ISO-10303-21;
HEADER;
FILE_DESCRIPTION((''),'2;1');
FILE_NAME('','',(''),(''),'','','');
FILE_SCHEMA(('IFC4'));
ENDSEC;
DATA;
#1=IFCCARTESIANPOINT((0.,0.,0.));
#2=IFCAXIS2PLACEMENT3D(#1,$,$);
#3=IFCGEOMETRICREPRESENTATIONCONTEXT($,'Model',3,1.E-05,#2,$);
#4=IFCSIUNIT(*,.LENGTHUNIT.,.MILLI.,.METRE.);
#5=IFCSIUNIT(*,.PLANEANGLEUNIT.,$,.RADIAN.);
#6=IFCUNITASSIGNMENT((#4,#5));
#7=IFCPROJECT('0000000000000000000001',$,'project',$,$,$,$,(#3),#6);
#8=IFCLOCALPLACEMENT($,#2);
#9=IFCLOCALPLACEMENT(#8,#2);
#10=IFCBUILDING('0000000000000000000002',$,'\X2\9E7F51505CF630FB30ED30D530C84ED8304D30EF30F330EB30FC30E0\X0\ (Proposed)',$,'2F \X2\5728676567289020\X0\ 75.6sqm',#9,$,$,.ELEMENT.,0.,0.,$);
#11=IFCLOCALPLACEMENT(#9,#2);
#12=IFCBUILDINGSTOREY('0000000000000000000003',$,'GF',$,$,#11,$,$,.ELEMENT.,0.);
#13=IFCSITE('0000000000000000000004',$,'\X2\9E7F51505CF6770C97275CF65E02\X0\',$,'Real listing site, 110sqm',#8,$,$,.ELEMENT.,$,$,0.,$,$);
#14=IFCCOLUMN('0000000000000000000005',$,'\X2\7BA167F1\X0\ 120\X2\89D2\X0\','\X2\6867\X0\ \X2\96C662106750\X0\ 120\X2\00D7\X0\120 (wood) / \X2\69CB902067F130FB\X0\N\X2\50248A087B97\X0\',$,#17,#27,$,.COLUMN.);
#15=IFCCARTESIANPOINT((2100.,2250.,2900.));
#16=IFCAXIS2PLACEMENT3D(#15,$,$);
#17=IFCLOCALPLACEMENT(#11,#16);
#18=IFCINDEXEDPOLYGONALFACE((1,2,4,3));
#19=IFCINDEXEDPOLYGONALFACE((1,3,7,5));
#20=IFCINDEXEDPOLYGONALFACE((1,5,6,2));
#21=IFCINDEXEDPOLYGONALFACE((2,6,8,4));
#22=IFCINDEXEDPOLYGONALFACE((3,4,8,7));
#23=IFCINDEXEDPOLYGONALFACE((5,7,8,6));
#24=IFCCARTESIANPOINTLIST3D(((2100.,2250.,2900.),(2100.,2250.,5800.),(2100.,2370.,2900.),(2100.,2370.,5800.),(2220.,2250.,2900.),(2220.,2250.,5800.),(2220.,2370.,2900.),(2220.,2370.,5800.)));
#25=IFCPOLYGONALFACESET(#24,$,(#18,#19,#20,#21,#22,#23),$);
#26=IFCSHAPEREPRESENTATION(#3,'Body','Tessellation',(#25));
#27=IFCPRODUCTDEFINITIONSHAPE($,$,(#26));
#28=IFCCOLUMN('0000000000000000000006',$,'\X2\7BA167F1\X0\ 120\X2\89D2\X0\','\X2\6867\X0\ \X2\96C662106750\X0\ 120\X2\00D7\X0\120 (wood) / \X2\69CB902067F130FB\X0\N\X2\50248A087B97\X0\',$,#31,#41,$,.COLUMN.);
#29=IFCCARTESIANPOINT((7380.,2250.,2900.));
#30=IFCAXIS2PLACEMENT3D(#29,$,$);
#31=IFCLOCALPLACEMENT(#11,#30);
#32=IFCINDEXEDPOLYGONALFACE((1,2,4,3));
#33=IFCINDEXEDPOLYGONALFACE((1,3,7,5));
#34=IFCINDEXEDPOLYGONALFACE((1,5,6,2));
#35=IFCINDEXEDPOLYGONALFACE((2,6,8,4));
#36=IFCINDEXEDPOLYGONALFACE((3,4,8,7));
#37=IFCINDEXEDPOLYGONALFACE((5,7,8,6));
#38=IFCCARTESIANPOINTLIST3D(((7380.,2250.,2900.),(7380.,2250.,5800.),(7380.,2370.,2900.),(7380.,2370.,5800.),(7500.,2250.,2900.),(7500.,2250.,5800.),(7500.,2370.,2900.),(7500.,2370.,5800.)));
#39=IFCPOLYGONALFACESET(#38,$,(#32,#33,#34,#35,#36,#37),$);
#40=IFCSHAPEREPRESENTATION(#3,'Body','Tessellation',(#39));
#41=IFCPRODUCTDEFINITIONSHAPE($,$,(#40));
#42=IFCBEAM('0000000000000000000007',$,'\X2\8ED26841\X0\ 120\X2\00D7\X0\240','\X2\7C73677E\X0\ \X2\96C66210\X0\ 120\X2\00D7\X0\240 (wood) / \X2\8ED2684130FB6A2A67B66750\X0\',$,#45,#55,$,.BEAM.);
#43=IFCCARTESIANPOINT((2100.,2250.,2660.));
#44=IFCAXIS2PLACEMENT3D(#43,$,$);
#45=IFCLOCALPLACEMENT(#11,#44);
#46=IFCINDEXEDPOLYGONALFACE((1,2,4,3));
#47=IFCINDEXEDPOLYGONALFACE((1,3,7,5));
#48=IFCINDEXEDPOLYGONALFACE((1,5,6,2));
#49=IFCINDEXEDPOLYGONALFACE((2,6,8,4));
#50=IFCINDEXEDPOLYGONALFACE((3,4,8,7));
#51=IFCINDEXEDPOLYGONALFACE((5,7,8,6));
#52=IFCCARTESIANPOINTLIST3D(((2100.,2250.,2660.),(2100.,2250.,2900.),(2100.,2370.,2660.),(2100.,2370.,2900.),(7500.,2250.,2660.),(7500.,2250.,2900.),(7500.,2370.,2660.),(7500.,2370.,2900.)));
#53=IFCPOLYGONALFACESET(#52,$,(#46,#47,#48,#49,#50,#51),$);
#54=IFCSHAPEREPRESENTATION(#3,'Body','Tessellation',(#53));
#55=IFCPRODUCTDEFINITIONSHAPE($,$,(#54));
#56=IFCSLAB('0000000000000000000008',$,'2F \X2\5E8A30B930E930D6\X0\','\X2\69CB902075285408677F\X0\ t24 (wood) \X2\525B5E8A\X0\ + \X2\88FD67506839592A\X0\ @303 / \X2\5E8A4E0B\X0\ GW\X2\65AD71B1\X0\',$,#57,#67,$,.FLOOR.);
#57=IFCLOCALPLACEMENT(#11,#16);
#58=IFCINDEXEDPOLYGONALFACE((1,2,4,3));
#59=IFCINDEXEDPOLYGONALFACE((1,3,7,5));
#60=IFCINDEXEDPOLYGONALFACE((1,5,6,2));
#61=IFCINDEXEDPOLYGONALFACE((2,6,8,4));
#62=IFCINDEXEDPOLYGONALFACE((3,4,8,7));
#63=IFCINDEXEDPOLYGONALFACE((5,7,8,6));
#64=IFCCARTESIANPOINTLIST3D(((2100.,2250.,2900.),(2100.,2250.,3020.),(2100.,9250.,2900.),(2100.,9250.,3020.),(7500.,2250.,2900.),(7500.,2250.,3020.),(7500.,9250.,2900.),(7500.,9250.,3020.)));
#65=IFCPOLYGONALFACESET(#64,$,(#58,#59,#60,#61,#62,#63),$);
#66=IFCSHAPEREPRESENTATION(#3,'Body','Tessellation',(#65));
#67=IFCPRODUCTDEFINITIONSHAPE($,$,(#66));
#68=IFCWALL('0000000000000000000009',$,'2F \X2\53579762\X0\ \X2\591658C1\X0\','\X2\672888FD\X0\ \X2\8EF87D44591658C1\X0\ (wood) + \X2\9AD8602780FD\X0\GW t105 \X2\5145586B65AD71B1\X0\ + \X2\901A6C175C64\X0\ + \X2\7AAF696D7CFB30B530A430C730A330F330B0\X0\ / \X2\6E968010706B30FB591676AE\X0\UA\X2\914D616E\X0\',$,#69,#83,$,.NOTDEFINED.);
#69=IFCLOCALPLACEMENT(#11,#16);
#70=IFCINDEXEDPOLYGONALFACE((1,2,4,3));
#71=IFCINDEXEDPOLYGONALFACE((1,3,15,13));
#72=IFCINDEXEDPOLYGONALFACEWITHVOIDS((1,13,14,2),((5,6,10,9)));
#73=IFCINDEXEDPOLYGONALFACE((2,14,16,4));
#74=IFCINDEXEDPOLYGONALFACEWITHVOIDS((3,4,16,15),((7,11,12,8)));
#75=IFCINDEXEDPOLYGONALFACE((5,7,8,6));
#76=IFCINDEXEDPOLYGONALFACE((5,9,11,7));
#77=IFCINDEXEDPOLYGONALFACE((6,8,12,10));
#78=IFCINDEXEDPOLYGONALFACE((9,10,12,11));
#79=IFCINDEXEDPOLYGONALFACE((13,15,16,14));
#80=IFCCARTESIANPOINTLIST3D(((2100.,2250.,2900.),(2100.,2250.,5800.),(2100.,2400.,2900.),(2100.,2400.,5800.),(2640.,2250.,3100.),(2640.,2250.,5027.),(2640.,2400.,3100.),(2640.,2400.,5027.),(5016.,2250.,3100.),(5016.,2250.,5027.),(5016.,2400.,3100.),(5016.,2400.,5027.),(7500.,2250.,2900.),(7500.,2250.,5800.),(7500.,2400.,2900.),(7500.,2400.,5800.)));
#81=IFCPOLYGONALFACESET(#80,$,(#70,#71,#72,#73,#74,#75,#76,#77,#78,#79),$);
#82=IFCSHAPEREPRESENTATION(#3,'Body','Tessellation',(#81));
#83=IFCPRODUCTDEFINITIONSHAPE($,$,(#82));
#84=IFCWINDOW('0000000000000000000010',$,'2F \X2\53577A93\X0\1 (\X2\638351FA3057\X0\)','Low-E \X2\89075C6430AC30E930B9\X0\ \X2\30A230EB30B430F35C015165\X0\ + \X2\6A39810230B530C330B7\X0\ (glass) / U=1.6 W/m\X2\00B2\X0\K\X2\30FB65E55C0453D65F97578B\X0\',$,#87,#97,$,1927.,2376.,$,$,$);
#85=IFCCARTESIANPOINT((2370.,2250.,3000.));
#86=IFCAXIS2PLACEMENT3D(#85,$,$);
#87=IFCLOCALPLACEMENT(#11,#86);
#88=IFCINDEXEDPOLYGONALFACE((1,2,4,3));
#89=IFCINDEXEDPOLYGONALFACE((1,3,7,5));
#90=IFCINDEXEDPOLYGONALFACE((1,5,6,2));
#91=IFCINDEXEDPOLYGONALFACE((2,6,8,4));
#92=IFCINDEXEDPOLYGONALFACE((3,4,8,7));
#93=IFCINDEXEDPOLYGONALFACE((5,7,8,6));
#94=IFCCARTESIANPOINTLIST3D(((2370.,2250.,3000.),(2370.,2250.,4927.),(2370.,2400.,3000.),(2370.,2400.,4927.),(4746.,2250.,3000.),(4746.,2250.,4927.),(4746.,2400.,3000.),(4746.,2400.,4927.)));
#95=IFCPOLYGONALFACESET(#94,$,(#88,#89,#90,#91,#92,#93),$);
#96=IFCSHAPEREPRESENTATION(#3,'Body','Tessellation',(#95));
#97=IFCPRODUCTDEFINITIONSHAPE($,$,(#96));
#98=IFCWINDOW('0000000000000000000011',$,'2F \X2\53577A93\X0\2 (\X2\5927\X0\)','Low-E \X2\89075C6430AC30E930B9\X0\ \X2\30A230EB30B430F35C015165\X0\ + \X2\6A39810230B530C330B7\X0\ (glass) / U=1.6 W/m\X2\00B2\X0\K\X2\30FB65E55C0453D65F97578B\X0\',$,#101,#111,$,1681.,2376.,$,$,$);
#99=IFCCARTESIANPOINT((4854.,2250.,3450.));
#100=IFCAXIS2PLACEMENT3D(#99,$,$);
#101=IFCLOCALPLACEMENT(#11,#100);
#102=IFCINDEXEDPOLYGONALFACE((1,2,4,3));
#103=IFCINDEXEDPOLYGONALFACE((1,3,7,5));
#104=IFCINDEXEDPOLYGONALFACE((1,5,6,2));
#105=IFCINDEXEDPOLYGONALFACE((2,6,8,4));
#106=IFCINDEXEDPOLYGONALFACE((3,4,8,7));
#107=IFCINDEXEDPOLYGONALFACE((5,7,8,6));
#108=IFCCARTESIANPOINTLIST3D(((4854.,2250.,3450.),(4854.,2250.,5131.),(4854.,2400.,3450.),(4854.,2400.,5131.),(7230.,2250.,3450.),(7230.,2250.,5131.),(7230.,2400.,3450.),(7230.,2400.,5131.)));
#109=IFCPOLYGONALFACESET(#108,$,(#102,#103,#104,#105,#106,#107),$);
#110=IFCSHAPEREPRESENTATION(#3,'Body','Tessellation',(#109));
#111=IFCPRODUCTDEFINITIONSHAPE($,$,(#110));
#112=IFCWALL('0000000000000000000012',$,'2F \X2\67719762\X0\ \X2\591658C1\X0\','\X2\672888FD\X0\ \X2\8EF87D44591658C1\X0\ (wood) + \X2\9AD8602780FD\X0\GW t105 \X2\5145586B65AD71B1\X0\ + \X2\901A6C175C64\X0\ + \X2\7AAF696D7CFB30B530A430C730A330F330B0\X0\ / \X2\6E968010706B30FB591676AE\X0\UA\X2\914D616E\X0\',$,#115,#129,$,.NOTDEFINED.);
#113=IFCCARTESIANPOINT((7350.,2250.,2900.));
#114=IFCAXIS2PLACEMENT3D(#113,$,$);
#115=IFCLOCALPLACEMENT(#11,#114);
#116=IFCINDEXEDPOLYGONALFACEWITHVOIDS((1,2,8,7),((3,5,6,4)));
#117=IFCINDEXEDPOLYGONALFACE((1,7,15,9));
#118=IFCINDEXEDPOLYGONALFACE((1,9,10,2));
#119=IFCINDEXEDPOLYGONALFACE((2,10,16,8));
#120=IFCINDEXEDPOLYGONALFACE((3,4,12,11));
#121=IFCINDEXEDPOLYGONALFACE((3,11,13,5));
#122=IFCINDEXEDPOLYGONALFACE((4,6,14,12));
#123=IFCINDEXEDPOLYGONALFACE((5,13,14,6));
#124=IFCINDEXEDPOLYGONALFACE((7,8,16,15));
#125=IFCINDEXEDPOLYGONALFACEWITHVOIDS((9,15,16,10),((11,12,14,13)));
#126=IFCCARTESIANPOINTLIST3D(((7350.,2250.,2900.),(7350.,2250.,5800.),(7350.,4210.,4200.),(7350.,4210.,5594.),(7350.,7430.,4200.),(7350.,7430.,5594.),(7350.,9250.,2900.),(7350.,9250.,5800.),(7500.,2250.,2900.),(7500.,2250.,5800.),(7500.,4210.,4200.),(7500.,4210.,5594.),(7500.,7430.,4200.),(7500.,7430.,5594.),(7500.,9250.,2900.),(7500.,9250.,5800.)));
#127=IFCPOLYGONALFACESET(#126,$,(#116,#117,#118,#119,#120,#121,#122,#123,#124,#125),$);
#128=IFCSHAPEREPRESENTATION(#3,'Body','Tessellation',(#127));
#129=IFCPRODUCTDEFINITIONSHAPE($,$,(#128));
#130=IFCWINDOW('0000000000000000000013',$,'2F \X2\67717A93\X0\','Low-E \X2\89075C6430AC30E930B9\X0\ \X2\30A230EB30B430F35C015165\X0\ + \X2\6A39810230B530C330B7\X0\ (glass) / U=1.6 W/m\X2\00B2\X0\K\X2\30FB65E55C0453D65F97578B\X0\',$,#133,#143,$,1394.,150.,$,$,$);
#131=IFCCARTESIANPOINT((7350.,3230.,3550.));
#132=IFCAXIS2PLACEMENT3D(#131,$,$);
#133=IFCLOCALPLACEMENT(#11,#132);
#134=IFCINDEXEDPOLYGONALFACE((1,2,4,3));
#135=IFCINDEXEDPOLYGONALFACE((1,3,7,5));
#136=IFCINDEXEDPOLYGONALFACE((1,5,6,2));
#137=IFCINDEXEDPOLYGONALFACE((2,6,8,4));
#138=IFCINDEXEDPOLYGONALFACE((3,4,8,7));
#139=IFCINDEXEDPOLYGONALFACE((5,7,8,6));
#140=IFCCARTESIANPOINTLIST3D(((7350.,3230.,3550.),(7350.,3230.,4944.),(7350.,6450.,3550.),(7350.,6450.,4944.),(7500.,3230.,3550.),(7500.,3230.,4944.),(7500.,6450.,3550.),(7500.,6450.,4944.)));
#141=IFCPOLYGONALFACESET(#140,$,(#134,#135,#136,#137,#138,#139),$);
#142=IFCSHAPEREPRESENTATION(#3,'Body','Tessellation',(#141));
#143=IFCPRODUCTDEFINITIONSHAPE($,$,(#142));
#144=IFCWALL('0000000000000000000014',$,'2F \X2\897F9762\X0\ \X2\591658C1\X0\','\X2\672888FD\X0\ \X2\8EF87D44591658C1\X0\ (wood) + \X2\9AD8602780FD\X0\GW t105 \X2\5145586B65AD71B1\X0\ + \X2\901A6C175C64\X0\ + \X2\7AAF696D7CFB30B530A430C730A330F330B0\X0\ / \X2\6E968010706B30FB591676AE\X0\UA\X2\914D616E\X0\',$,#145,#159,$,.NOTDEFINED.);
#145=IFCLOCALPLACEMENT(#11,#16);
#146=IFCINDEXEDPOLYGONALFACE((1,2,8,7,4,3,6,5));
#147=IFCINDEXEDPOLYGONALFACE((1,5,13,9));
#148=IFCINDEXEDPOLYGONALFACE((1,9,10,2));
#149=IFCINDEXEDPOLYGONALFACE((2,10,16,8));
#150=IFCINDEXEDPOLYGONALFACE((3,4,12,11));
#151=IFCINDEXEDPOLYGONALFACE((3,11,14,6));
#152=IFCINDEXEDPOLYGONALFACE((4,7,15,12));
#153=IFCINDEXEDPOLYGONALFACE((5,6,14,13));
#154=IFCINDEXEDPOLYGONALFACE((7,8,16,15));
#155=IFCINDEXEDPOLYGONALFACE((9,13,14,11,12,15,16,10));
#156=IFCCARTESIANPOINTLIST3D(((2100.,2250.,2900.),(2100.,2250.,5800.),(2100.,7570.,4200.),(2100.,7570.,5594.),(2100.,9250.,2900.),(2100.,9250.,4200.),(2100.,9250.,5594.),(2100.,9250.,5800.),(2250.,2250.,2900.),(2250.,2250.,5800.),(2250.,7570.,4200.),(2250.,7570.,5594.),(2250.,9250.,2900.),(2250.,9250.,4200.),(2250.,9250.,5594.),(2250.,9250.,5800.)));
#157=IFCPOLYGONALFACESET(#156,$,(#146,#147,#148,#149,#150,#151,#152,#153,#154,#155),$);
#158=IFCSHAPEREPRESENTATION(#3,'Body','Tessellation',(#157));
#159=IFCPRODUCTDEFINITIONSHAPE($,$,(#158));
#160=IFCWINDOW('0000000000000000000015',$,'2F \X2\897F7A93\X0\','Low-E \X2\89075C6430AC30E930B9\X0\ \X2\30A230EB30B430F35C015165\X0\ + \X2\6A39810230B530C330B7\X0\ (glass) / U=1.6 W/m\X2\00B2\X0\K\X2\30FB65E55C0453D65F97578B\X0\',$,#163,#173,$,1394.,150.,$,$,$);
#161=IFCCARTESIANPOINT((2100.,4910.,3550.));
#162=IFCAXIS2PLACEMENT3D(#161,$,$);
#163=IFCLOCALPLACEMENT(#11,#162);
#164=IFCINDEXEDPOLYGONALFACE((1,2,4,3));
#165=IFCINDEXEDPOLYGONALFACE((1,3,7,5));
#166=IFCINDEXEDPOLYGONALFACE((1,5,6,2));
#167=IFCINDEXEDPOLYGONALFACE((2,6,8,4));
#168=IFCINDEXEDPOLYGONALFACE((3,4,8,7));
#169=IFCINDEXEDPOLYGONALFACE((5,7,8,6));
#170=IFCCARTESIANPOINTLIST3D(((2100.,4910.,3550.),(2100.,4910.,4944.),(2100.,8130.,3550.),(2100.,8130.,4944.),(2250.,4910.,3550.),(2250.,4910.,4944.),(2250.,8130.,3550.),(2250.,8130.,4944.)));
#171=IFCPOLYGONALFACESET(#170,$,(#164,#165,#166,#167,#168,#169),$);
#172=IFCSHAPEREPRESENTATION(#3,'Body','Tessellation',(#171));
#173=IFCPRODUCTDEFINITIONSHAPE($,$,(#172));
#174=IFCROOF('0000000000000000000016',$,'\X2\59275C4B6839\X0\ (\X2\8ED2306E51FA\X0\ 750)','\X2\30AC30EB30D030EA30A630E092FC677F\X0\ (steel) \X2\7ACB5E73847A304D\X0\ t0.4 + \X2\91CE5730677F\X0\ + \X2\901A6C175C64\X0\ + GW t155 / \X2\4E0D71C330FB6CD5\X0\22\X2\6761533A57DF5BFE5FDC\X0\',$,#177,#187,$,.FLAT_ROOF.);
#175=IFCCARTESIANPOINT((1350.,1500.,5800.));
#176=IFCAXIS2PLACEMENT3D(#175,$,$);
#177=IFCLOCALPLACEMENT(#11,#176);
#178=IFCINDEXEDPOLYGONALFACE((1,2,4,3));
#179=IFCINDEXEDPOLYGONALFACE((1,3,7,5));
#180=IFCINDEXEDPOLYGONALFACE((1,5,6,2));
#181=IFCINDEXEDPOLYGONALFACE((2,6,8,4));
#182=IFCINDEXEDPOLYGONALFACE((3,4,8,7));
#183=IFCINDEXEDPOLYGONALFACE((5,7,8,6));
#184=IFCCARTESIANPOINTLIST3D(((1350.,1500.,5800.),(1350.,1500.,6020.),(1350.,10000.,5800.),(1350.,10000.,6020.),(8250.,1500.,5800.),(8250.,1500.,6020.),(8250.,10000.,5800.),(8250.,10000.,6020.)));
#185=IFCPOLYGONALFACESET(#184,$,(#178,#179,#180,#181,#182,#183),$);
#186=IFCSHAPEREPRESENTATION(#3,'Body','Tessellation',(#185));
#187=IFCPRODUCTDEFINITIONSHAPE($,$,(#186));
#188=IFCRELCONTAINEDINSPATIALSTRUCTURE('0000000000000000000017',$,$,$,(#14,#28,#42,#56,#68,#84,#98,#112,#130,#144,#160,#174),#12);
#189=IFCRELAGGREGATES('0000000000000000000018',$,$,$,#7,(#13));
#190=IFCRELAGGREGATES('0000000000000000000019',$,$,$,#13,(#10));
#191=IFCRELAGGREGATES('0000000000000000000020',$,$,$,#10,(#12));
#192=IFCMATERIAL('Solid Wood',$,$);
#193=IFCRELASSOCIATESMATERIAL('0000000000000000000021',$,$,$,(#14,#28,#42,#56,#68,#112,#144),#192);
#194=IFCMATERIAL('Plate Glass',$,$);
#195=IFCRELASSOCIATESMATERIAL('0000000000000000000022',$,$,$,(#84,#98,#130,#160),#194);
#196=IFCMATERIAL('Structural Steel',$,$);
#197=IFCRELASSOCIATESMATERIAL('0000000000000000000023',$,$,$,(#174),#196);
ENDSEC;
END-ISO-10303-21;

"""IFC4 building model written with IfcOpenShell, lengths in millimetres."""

from ifc_helpers import new_model, si_unit, frame, frame_2d, origin, place, context, project, spatial, rectangle, extrude, material, element, fill, save


model = new_model("IFC4")

# Units and contexts
model_context = context("Model", 3, precision=1e-05, world=origin())
ifc_project = project(units=[si_unit("LENGTHUNIT", "METRE", prefix="MILLI"), si_unit("PLANEANGLEUNIT", "RADIAN")], contexts=[model_context])

# Site, building, storey
site_placement = place(None, origin())
site = spatial("IfcSite", under=ifc_project, at=site_placement, Name="鹿児島県霧島市", ObjectType="Real listing site, 110sqm", CompositionType="ELEMENT", RefElevation=0.0)
building_placement = place(site_placement, origin())
building = spatial("IfcBuilding", under=site, at=building_placement, Name="鹿児島・ロフト付きワンルーム (Proposed)", ObjectType="2F 在来木造 75.6sqm", CompositionType="ELEMENT", ElevationOfRefHeight=0.0, ElevationOfTerrain=0.0)
storey_placement = place(building_placement, origin())
storey = spatial("IfcBuildingStorey", under=building, at=storey_placement, Name="GF", CompositionType="ELEMENT", Elevation=0.0)

# Columns
ifc_material_1 = material(Name="Solid Wood")
column_1_placement = place(storey_placement, frame((2100.0, 2250.0, 2900.0)))
element("IfcColumn", 1, at=column_1_placement, inside=storey, material=ifc_material_1, Name="管柱 120角", Description="桧 集成材 120×120 (wood) / 構造柱・N値計算", PredefinedType="COLUMN", context=model_context, shape_type="SweptSolid", body=[
    extrude(rectangle(XDim=120.0, YDim=120.0, at=frame_2d((60.0, 60.0))), frame((2100.0, 2250.0, 2900.0)), (0.0, 0.0, 1.0), 2900.0),
])
column_2_placement = place(storey_placement, frame((7380.0, 2250.0, 2900.0)))
element("IfcColumn", 2, at=column_2_placement, inside=storey, material=ifc_material_1, Name="管柱 120角", Description="桧 集成材 120×120 (wood) / 構造柱・N値計算", PredefinedType="COLUMN", context=model_context, shape_type="SweptSolid", body=[
    extrude(rectangle(XDim=120.0, YDim=120.0, at=frame_2d((60.0, 60.0))), frame((7380.0, 2250.0, 2900.0)), (0.0, 0.0, 1.0), 2900.0),
])

# Beam
beam_1_placement = place(storey_placement, frame((2100.0, 2250.0, 2660.0)))
element("IfcBeam", 3, at=beam_1_placement, inside=storey, material=ifc_material_1, Name="軒桁 120×240", Description="米松 集成 120×240 (wood) / 軒桁・横架材", PredefinedType="BEAM", context=model_context, shape_type="SweptSolid", body=[
    extrude(rectangle(XDim=5400.0, YDim=120.0, at=frame_2d((2700.0, 60.0))), frame((2100.0, 2250.0, 2660.0)), (0.0, 0.0, 1.0), 240.0),
])

# Slab
slab_placement = place(storey_placement, frame((2100.0, 2250.0, 2900.0)))
element("IfcSlab", 4, at=slab_placement, inside=storey, material=ifc_material_1, Name="2F 床スラブ", Description="構造用合板 t24 (wood) 剛床 + 製材根太 @303 / 床下 GW断熱", PredefinedType="FLOOR", context=model_context, shape_type="SweptSolid", body=[
    extrude(rectangle(XDim=5400.0, YDim=7000.0, at=frame_2d((2700.0, 3500.0))), frame((2100.0, 2250.0, 2900.0)), (0.0, 0.0, 1.0), 120.0),
])

# Wall, openings, windows
wall_1_placement = place(storey_placement, frame((2100.0, 2250.0, 2900.0)))
wall_1 = element("IfcWall", 5, at=wall_1_placement, inside=storey, material=ifc_material_1, Name="2F 南面 外壁", Description="木製 軸組外壁 (wood) + 高性能GW t105 充填断熱 + 通気層 + 窯業系サイディング / 準耐火・外皮UA配慮", PredefinedType="NOTDEFINED", context=model_context, shape_type="SweptSolid", body=[
    extrude(rectangle(XDim=5400.0, YDim=150.0, at=frame_2d((2700.0, 75.0))), frame((2100.0, 2250.0, 2900.0)), (0.0, 0.0, 1.0), 2900.0),
])
opening_1_placement = place(storey_placement, frame((2370.0, 2250.0, 3000.0)))
opening_1 = element("IfcOpeningElement", 6, at=opening_1_placement, cuts=wall_1, PredefinedType="NOTDEFINED", context=model_context, shape_type="SweptSolid", body=[
    extrude(rectangle(XDim=2376.0, YDim=150.0, at=frame_2d((1188.0, 75.0))), frame((2370.0, 2250.0, 3000.0)), (0.0, 0.0, 1.0), 1927.0),
])
opening_2_placement = place(storey_placement, frame((4854.0, 2250.0, 3450.0)))
opening_2 = element("IfcOpeningElement", 7, at=opening_2_placement, cuts=wall_1, PredefinedType="NOTDEFINED", context=model_context, shape_type="SweptSolid", body=[
    extrude(rectangle(XDim=2376.0, YDim=150.0, at=frame_2d((1188.0, 75.0))), frame((4854.0, 2250.0, 3450.0)), (0.0, 0.0, 1.0), 1681.0),
])
ifc_material_2 = material(Name="Plate Glass")
window_1_placement = place(storey_placement, frame((2370.0, 2250.0, 3000.0)))
window_1 = element("IfcWindow", 8, at=window_1_placement, inside=storey, material=ifc_material_2, Name="2F 南窓1 (掃出し)", Description="Low-E 複層ガラス アルゴン封入 + 樹脂サッシ (glass) / U=1.6 W/m²K・日射取得型", OverallHeight=1927.0, OverallWidth=2376.0, context=model_context, shape_type="SweptSolid", body=[
    extrude(rectangle(XDim=2376.0, YDim=150.0, at=frame_2d((1188.0, 75.0))), frame((2370.0, 2250.0, 3000.0)), (0.0, 0.0, 1.0), 1927.0),
])
fill(opening_1, window_1)
window_2_placement = place(storey_placement, frame((4854.0, 2250.0, 3450.0)))
window_2 = element("IfcWindow", 9, at=window_2_placement, inside=storey, material=ifc_material_2, Name="2F 南窓2 (大)", Description="Low-E 複層ガラス アルゴン封入 + 樹脂サッシ (glass) / U=1.6 W/m²K・日射取得型", OverallHeight=1681.0, OverallWidth=2376.0, context=model_context, shape_type="SweptSolid", body=[
    extrude(rectangle(XDim=2376.0, YDim=150.0, at=frame_2d((1188.0, 75.0))), frame((4854.0, 2250.0, 3450.0)), (0.0, 0.0, 1.0), 1681.0),
])
fill(opening_2, window_2)

# Walls, openings, windows
wall_2_placement = place(storey_placement, frame((7350.0, 2250.0, 2900.0)))
wall_2 = element("IfcWall", 10, at=wall_2_placement, inside=storey, material=ifc_material_1, Name="2F 東面 外壁", Description="木製 軸組外壁 (wood) + 高性能GW t105 充填断熱 + 通気層 + 窯業系サイディング / 準耐火・外皮UA配慮", PredefinedType="NOTDEFINED", context=model_context, shape_type="SweptSolid", body=[
    extrude(rectangle(XDim=150.0, YDim=7000.0, at=frame_2d((75.0, 3500.0))), frame((7350.0, 2250.0, 2900.0)), (0.0, 0.0, 1.0), 2900.0),
])
opening_3_placement = place(storey_placement, frame((7350.0, 3230.0, 3550.0)))
opening_3 = element("IfcOpeningElement", 11, at=opening_3_placement, cuts=wall_2, PredefinedType="NOTDEFINED", context=model_context, shape_type="SweptSolid", body=[
    extrude(rectangle(XDim=150.0, YDim=3220.0, at=frame_2d((75.0, 1610.0))), frame((7350.0, 3230.0, 3550.0)), (0.0, 0.0, 1.0), 1394.0),
])
window_3_placement = place(storey_placement, frame((7350.0, 3230.0, 3550.0)))
window_3 = element("IfcWindow", 12, at=window_3_placement, inside=storey, material=ifc_material_2, Name="2F 東窓", Description="Low-E 複層ガラス アルゴン封入 + 樹脂サッシ (glass) / U=1.6 W/m²K・日射取得型", OverallHeight=1394.0, OverallWidth=150.0, context=model_context, shape_type="SweptSolid", body=[
    extrude(rectangle(XDim=150.0, YDim=3220.0, at=frame_2d((75.0, 1610.0))), frame((7350.0, 3230.0, 3550.0)), (0.0, 0.0, 1.0), 1394.0),
])
fill(opening_3, window_3)
wall_3_placement = place(storey_placement, frame((2100.0, 2250.0, 2900.0)))
wall_3 = element("IfcWall", 13, at=wall_3_placement, inside=storey, material=ifc_material_1, Name="2F 西面 外壁", Description="木製 軸組外壁 (wood) + 高性能GW t105 充填断熱 + 通気層 + 窯業系サイディング / 準耐火・外皮UA配慮", PredefinedType="NOTDEFINED", context=model_context, shape_type="SweptSolid", body=[
    extrude(rectangle(XDim=150.0, YDim=7000.0, at=frame_2d((75.0, 3500.0))), frame((2100.0, 2250.0, 2900.0)), (0.0, 0.0, 1.0), 2900.0),
])
opening_4_placement = place(storey_placement, frame((2100.0, 4910.0, 3550.0)))
opening_4 = element("IfcOpeningElement", 14, at=opening_4_placement, cuts=wall_3, PredefinedType="NOTDEFINED", context=model_context, shape_type="SweptSolid", body=[
    extrude(rectangle(XDim=150.0, YDim=3220.0, at=frame_2d((75.0, 1610.0))), frame((2100.0, 4910.0, 3550.0)), (0.0, 0.0, 1.0), 1394.0),
])
window_4_placement = place(storey_placement, frame((2100.0, 4910.0, 3550.0)))
window_4 = element("IfcWindow", 15, at=window_4_placement, inside=storey, material=ifc_material_2, Name="2F 西窓", Description="Low-E 複層ガラス アルゴン封入 + 樹脂サッシ (glass) / U=1.6 W/m²K・日射取得型", OverallHeight=1394.0, OverallWidth=150.0, context=model_context, shape_type="SweptSolid", body=[
    extrude(rectangle(XDim=150.0, YDim=3220.0, at=frame_2d((75.0, 1610.0))), frame((2100.0, 4910.0, 3550.0)), (0.0, 0.0, 1.0), 1394.0),
])
fill(opening_4, window_4)

# Roof
ifc_material_3 = material(Name="Structural Steel")
roof_placement = place(storey_placement, frame((1350.0, 1500.0, 5800.0)))
element("IfcRoof", 16, at=roof_placement, inside=storey, material=ifc_material_3, Name="大屋根 (軒の出 750)", Description="ガルバリウム鋼板 (steel) 立平葺き t0.4 + 野地板 + 通気層 + GW t155 / 不燃・法22条区域対応", PredefinedType="FLAT_ROOF", context=model_context, shape_type="SweptSolid", body=[
    extrude(rectangle(XDim=6900.0, YDim=8500.0, at=frame_2d((3450.0, 4250.0))), frame((1350.0, 1500.0, 5800.0)), (0.0, 0.0, 1.0), 220.0),
])

save(model, "model.ifc")
